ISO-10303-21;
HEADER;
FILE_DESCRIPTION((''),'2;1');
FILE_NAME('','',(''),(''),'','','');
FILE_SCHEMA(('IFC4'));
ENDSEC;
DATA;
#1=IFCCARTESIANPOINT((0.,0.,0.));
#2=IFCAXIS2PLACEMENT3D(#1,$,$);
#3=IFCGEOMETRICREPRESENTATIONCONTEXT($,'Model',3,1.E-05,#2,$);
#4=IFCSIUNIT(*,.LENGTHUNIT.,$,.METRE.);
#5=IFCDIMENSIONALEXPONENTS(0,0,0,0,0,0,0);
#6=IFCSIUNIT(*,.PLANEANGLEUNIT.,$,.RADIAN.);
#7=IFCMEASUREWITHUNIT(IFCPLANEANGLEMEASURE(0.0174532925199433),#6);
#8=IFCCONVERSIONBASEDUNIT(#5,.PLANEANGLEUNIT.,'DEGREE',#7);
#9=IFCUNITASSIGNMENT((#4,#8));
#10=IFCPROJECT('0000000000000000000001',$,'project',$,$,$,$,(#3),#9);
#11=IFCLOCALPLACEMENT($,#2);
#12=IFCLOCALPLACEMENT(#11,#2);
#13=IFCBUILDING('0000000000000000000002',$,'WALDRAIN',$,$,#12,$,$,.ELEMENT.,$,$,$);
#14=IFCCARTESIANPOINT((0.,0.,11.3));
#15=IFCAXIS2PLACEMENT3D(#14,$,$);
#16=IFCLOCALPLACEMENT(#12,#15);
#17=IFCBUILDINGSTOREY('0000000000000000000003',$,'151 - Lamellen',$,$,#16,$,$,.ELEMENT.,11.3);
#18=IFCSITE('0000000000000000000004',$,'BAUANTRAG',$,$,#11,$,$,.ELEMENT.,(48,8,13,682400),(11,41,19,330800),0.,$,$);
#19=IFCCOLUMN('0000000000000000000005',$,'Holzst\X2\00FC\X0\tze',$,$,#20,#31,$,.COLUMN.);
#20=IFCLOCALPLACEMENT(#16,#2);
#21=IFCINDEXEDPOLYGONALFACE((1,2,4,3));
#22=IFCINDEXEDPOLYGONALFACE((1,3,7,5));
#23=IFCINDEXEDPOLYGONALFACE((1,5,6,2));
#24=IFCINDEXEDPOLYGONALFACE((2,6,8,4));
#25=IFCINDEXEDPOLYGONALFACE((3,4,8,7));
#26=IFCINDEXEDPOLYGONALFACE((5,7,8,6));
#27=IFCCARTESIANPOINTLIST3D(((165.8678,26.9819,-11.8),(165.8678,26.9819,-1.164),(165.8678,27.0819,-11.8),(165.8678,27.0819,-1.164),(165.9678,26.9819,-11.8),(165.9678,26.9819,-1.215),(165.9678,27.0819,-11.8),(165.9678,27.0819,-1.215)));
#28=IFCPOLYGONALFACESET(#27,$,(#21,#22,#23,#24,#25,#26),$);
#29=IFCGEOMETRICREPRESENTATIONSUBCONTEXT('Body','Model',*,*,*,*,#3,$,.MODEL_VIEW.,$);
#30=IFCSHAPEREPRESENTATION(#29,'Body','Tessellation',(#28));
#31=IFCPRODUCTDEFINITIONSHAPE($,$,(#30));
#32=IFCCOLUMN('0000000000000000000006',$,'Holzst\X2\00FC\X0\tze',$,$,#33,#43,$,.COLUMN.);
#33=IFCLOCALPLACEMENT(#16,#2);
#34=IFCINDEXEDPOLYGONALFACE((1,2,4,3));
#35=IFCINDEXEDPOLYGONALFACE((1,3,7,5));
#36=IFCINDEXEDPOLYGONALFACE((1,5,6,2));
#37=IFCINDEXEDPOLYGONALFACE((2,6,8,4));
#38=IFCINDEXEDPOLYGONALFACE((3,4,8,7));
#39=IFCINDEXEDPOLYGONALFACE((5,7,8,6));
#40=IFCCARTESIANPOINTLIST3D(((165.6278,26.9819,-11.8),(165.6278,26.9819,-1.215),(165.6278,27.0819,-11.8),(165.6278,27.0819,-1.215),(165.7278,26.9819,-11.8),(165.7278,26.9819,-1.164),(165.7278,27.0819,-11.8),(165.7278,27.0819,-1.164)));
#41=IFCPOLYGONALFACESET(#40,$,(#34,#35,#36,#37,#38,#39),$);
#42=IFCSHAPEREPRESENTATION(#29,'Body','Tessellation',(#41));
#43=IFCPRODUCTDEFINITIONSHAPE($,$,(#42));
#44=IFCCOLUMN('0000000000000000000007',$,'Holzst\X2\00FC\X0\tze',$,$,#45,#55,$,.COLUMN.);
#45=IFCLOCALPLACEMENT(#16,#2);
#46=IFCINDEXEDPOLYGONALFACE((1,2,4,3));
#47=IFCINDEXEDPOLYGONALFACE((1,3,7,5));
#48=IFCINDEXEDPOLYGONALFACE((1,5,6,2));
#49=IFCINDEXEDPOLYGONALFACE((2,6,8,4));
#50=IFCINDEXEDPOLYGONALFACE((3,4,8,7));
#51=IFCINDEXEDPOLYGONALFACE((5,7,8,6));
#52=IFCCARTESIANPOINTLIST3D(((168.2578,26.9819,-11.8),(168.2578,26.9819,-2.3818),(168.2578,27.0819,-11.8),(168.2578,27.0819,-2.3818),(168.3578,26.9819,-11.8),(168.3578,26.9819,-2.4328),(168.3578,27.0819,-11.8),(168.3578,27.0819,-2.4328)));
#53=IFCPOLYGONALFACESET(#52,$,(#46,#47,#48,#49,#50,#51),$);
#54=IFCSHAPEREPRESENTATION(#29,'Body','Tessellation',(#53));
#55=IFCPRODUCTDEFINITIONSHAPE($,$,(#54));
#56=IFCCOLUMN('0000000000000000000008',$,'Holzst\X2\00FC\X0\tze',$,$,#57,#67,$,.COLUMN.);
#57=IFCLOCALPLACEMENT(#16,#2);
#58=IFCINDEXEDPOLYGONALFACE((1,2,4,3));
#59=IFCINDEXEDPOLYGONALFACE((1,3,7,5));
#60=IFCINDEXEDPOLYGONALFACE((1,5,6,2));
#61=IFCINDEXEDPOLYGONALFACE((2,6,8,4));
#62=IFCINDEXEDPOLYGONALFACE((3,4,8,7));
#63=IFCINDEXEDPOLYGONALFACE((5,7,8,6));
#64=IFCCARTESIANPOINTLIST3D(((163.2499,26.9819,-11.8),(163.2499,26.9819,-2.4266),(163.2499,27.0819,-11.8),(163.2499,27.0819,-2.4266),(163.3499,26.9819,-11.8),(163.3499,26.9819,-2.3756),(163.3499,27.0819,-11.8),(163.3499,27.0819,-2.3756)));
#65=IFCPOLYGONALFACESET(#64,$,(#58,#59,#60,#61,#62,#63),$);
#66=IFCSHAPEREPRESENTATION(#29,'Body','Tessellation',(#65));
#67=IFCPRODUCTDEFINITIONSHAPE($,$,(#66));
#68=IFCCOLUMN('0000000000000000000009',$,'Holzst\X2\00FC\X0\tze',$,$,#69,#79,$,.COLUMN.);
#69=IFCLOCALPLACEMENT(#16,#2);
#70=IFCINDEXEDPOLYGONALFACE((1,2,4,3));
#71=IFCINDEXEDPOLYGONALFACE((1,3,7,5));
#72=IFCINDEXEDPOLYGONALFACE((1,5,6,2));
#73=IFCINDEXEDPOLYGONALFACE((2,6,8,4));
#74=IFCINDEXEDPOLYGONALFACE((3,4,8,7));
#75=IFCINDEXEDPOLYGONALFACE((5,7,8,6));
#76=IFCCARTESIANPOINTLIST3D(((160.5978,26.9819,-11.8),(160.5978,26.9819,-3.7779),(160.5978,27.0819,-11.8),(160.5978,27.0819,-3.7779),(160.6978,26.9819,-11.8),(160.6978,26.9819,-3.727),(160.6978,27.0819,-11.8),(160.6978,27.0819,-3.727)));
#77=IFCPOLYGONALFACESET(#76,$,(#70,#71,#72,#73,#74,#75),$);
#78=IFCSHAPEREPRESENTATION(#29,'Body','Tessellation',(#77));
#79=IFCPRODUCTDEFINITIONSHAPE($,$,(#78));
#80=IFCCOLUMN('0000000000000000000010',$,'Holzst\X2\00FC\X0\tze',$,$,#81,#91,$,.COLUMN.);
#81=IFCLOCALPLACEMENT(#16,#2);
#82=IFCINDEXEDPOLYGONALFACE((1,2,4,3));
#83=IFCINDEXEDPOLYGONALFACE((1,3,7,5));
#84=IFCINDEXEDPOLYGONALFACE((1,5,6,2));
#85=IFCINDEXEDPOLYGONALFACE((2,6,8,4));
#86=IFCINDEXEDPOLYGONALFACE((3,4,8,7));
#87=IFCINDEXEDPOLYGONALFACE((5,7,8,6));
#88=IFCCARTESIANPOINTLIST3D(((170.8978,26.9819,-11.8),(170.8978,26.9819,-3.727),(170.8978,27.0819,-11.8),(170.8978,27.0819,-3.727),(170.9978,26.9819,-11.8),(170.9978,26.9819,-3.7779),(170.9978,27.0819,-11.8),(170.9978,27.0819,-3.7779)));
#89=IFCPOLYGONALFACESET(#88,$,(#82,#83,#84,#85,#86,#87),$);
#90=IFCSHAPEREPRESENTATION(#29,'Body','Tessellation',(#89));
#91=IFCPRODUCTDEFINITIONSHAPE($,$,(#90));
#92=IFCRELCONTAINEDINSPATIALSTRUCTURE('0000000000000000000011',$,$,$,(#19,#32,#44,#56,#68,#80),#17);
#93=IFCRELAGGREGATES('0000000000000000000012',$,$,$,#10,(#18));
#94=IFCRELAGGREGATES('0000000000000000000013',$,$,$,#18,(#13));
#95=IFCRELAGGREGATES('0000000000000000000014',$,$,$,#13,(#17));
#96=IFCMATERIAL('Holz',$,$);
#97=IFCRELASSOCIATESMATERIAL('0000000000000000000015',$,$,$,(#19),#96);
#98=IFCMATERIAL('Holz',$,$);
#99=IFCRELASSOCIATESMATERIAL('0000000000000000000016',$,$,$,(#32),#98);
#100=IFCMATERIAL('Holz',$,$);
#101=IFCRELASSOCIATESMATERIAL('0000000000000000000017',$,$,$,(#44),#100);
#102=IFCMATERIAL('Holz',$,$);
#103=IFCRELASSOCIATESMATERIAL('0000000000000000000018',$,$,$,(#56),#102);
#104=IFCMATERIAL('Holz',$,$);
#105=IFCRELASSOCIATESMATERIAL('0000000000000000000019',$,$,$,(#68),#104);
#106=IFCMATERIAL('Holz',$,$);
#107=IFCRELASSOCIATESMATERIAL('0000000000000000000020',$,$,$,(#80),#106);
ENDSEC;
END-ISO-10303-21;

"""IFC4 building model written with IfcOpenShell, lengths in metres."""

from ifc_helpers import new_model, entity, si_unit, converted_unit, frame, frame_2d, origin, origin_with_axes, place, context, subcontext, project, spatial, rectangle, extrude, clip, halfspace, material, element, save


model = new_model("IFC4")

# Units and contexts
model_context = context("Model", 3, precision=1e-05, world=origin())
body_context = subcontext(model_context, "Body", "Model", "MODEL_VIEW")
ifc_project = project(units=[si_unit("LENGTHUNIT", "METRE"), converted_unit("PLANEANGLEUNIT", "DEGREE", entity("IfcPlaneAngleMeasure", 0.0174532925199433), si_unit("PLANEANGLEUNIT", "RADIAN"), dimensions=[0, 0, 0, 0, 0, 0, 0])], contexts=[model_context])

# Site, building, storey
site_placement = place(None, origin())
site = spatial("IfcSite", under=ifc_project, at=site_placement, Name="BAUANTRAG", CompositionType="ELEMENT", RefLatitude=(48, 8, 13, 682400), RefLongitude=(11, 41, 19, 330800), RefElevation=0.0)
building_placement = place(site_placement, origin())
building = spatial("IfcBuilding", under=site, at=building_placement, Name="WALDRAIN", CompositionType="ELEMENT")
storey_placement = place(building_placement, frame((0.0, 0.0, 11.3)))
storey = spatial("IfcBuildingStorey", under=building, at=storey_placement, Name="151 - Lamellen", CompositionType="ELEMENT", Elevation=11.3)

# Columns
ifc_material_1 = material(Name="Holz")
column_1_placement = place(storey_placement, frame((165.9678, 26.9819, -11.8)))
element("IfcColumn", 1, at=column_1_placement, inside=storey, material=ifc_material_1, Name="Holzstütze", PredefinedType="COLUMN", context=body_context, shape_type="Clipping", body=[
    clip(extrude(rectangle(XDim=0.1, YDim=0.1, at=frame_2d((-0.05, 0.05), x_axis=(0.0, 1.0))), origin_with_axes(), (0.0, 0.0, 1.0), 10.636), halfspace(frame((-0.05, 0.05, 10.6105), z_axis=(-0.45399, 0.0, -0.891007), x_axis=(0.0, -1.0, 0.0)), True)),
])
ifc_material_2 = material(Name="Holz")
column_2_placement = place(storey_placement, frame((165.7278, 26.9819, -11.8)))
element("IfcColumn", 2, at=column_2_placement, inside=storey, material=ifc_material_2, Name="Holzstütze", PredefinedType="COLUMN", context=body_context, shape_type="Clipping", body=[
    clip(extrude(rectangle(XDim=0.1, YDim=0.1, at=frame_2d((-0.05, 0.05), x_axis=(0.0, 1.0))), origin_with_axes(), (0.0, 0.0, 1.0), 10.636), halfspace(frame((-0.05, 0.05, 10.6105), z_axis=(0.45399, 0.0, -0.891007), x_axis=(0.0, -1.0, 0.0)), True)),
])
ifc_material_3 = material(Name="Holz")
column_3_placement = place(storey_placement, frame((168.3578, 26.9819, -11.8)))
element("IfcColumn", 3, at=column_3_placement, inside=storey, material=ifc_material_3, Name="Holzstütze", PredefinedType="COLUMN", context=body_context, shape_type="Clipping", body=[
    clip(extrude(rectangle(XDim=0.1, YDim=0.1, at=frame_2d((-0.05, 0.05), x_axis=(0.0, 1.0))), origin_with_axes(), (0.0, 0.0, 1.0), 9.4182), halfspace(frame((-0.05, 0.05, 9.3927), z_axis=(-0.45399, 0.0, -0.891007), x_axis=(0.0, -1.0, 0.0)), True)),
])
ifc_material_4 = material(Name="Holz")
column_4_placement = place(storey_placement, frame((163.3499, 26.9819, -11.8)))
element("IfcColumn", 4, at=column_4_placement, inside=storey, material=ifc_material_4, Name="Holzstütze", PredefinedType="COLUMN", context=body_context, shape_type="Clipping", body=[
    clip(extrude(rectangle(XDim=0.1, YDim=0.1, at=frame_2d((-0.05, 0.05), x_axis=(0.0, 1.0))), origin_with_axes(), (0.0, 0.0, 1.0), 9.4244), halfspace(frame((-0.05, 0.05, 9.3989), z_axis=(0.45399, 0.0, -0.891007), x_axis=(0.0, -1.0, 0.0)), True)),
])
ifc_material_5 = material(Name="Holz")
column_5_placement = place(storey_placement, frame((160.6978, 26.9819, -11.8)))
element("IfcColumn", 5, at=column_5_placement, inside=storey, material=ifc_material_5, Name="Holzstütze", PredefinedType="COLUMN", context=body_context, shape_type="Clipping", body=[
    clip(extrude(rectangle(XDim=0.1, YDim=0.1, at=frame_2d((-0.05, 0.05), x_axis=(0.0, 1.0))), origin_with_axes(), (0.0, 0.0, 1.0), 8.073), halfspace(frame((-0.05, 0.05, 8.0476), z_axis=(0.45399, 0.0, -0.891007), x_axis=(0.0, -1.0, 0.0)), True)),
])
ifc_material_6 = material(Name="Holz")
column_6_placement = place(storey_placement, frame((170.9978, 26.9819, -11.8)))
element("IfcColumn", 6, at=column_6_placement, inside=storey, material=ifc_material_6, Name="Holzstütze", PredefinedType="COLUMN", context=body_context, shape_type="Clipping", body=[
    clip(extrude(rectangle(XDim=0.1, YDim=0.1, at=frame_2d((-0.05, 0.05), x_axis=(0.0, 1.0))), origin_with_axes(), (0.0, 0.0, 1.0), 8.073), halfspace(frame((-0.05, 0.05, 8.0476), z_axis=(-0.45399, 0.0, -0.891007), x_axis=(0.0, -1.0, 0.0)), True)),
])

save(model, "model.ifc")
